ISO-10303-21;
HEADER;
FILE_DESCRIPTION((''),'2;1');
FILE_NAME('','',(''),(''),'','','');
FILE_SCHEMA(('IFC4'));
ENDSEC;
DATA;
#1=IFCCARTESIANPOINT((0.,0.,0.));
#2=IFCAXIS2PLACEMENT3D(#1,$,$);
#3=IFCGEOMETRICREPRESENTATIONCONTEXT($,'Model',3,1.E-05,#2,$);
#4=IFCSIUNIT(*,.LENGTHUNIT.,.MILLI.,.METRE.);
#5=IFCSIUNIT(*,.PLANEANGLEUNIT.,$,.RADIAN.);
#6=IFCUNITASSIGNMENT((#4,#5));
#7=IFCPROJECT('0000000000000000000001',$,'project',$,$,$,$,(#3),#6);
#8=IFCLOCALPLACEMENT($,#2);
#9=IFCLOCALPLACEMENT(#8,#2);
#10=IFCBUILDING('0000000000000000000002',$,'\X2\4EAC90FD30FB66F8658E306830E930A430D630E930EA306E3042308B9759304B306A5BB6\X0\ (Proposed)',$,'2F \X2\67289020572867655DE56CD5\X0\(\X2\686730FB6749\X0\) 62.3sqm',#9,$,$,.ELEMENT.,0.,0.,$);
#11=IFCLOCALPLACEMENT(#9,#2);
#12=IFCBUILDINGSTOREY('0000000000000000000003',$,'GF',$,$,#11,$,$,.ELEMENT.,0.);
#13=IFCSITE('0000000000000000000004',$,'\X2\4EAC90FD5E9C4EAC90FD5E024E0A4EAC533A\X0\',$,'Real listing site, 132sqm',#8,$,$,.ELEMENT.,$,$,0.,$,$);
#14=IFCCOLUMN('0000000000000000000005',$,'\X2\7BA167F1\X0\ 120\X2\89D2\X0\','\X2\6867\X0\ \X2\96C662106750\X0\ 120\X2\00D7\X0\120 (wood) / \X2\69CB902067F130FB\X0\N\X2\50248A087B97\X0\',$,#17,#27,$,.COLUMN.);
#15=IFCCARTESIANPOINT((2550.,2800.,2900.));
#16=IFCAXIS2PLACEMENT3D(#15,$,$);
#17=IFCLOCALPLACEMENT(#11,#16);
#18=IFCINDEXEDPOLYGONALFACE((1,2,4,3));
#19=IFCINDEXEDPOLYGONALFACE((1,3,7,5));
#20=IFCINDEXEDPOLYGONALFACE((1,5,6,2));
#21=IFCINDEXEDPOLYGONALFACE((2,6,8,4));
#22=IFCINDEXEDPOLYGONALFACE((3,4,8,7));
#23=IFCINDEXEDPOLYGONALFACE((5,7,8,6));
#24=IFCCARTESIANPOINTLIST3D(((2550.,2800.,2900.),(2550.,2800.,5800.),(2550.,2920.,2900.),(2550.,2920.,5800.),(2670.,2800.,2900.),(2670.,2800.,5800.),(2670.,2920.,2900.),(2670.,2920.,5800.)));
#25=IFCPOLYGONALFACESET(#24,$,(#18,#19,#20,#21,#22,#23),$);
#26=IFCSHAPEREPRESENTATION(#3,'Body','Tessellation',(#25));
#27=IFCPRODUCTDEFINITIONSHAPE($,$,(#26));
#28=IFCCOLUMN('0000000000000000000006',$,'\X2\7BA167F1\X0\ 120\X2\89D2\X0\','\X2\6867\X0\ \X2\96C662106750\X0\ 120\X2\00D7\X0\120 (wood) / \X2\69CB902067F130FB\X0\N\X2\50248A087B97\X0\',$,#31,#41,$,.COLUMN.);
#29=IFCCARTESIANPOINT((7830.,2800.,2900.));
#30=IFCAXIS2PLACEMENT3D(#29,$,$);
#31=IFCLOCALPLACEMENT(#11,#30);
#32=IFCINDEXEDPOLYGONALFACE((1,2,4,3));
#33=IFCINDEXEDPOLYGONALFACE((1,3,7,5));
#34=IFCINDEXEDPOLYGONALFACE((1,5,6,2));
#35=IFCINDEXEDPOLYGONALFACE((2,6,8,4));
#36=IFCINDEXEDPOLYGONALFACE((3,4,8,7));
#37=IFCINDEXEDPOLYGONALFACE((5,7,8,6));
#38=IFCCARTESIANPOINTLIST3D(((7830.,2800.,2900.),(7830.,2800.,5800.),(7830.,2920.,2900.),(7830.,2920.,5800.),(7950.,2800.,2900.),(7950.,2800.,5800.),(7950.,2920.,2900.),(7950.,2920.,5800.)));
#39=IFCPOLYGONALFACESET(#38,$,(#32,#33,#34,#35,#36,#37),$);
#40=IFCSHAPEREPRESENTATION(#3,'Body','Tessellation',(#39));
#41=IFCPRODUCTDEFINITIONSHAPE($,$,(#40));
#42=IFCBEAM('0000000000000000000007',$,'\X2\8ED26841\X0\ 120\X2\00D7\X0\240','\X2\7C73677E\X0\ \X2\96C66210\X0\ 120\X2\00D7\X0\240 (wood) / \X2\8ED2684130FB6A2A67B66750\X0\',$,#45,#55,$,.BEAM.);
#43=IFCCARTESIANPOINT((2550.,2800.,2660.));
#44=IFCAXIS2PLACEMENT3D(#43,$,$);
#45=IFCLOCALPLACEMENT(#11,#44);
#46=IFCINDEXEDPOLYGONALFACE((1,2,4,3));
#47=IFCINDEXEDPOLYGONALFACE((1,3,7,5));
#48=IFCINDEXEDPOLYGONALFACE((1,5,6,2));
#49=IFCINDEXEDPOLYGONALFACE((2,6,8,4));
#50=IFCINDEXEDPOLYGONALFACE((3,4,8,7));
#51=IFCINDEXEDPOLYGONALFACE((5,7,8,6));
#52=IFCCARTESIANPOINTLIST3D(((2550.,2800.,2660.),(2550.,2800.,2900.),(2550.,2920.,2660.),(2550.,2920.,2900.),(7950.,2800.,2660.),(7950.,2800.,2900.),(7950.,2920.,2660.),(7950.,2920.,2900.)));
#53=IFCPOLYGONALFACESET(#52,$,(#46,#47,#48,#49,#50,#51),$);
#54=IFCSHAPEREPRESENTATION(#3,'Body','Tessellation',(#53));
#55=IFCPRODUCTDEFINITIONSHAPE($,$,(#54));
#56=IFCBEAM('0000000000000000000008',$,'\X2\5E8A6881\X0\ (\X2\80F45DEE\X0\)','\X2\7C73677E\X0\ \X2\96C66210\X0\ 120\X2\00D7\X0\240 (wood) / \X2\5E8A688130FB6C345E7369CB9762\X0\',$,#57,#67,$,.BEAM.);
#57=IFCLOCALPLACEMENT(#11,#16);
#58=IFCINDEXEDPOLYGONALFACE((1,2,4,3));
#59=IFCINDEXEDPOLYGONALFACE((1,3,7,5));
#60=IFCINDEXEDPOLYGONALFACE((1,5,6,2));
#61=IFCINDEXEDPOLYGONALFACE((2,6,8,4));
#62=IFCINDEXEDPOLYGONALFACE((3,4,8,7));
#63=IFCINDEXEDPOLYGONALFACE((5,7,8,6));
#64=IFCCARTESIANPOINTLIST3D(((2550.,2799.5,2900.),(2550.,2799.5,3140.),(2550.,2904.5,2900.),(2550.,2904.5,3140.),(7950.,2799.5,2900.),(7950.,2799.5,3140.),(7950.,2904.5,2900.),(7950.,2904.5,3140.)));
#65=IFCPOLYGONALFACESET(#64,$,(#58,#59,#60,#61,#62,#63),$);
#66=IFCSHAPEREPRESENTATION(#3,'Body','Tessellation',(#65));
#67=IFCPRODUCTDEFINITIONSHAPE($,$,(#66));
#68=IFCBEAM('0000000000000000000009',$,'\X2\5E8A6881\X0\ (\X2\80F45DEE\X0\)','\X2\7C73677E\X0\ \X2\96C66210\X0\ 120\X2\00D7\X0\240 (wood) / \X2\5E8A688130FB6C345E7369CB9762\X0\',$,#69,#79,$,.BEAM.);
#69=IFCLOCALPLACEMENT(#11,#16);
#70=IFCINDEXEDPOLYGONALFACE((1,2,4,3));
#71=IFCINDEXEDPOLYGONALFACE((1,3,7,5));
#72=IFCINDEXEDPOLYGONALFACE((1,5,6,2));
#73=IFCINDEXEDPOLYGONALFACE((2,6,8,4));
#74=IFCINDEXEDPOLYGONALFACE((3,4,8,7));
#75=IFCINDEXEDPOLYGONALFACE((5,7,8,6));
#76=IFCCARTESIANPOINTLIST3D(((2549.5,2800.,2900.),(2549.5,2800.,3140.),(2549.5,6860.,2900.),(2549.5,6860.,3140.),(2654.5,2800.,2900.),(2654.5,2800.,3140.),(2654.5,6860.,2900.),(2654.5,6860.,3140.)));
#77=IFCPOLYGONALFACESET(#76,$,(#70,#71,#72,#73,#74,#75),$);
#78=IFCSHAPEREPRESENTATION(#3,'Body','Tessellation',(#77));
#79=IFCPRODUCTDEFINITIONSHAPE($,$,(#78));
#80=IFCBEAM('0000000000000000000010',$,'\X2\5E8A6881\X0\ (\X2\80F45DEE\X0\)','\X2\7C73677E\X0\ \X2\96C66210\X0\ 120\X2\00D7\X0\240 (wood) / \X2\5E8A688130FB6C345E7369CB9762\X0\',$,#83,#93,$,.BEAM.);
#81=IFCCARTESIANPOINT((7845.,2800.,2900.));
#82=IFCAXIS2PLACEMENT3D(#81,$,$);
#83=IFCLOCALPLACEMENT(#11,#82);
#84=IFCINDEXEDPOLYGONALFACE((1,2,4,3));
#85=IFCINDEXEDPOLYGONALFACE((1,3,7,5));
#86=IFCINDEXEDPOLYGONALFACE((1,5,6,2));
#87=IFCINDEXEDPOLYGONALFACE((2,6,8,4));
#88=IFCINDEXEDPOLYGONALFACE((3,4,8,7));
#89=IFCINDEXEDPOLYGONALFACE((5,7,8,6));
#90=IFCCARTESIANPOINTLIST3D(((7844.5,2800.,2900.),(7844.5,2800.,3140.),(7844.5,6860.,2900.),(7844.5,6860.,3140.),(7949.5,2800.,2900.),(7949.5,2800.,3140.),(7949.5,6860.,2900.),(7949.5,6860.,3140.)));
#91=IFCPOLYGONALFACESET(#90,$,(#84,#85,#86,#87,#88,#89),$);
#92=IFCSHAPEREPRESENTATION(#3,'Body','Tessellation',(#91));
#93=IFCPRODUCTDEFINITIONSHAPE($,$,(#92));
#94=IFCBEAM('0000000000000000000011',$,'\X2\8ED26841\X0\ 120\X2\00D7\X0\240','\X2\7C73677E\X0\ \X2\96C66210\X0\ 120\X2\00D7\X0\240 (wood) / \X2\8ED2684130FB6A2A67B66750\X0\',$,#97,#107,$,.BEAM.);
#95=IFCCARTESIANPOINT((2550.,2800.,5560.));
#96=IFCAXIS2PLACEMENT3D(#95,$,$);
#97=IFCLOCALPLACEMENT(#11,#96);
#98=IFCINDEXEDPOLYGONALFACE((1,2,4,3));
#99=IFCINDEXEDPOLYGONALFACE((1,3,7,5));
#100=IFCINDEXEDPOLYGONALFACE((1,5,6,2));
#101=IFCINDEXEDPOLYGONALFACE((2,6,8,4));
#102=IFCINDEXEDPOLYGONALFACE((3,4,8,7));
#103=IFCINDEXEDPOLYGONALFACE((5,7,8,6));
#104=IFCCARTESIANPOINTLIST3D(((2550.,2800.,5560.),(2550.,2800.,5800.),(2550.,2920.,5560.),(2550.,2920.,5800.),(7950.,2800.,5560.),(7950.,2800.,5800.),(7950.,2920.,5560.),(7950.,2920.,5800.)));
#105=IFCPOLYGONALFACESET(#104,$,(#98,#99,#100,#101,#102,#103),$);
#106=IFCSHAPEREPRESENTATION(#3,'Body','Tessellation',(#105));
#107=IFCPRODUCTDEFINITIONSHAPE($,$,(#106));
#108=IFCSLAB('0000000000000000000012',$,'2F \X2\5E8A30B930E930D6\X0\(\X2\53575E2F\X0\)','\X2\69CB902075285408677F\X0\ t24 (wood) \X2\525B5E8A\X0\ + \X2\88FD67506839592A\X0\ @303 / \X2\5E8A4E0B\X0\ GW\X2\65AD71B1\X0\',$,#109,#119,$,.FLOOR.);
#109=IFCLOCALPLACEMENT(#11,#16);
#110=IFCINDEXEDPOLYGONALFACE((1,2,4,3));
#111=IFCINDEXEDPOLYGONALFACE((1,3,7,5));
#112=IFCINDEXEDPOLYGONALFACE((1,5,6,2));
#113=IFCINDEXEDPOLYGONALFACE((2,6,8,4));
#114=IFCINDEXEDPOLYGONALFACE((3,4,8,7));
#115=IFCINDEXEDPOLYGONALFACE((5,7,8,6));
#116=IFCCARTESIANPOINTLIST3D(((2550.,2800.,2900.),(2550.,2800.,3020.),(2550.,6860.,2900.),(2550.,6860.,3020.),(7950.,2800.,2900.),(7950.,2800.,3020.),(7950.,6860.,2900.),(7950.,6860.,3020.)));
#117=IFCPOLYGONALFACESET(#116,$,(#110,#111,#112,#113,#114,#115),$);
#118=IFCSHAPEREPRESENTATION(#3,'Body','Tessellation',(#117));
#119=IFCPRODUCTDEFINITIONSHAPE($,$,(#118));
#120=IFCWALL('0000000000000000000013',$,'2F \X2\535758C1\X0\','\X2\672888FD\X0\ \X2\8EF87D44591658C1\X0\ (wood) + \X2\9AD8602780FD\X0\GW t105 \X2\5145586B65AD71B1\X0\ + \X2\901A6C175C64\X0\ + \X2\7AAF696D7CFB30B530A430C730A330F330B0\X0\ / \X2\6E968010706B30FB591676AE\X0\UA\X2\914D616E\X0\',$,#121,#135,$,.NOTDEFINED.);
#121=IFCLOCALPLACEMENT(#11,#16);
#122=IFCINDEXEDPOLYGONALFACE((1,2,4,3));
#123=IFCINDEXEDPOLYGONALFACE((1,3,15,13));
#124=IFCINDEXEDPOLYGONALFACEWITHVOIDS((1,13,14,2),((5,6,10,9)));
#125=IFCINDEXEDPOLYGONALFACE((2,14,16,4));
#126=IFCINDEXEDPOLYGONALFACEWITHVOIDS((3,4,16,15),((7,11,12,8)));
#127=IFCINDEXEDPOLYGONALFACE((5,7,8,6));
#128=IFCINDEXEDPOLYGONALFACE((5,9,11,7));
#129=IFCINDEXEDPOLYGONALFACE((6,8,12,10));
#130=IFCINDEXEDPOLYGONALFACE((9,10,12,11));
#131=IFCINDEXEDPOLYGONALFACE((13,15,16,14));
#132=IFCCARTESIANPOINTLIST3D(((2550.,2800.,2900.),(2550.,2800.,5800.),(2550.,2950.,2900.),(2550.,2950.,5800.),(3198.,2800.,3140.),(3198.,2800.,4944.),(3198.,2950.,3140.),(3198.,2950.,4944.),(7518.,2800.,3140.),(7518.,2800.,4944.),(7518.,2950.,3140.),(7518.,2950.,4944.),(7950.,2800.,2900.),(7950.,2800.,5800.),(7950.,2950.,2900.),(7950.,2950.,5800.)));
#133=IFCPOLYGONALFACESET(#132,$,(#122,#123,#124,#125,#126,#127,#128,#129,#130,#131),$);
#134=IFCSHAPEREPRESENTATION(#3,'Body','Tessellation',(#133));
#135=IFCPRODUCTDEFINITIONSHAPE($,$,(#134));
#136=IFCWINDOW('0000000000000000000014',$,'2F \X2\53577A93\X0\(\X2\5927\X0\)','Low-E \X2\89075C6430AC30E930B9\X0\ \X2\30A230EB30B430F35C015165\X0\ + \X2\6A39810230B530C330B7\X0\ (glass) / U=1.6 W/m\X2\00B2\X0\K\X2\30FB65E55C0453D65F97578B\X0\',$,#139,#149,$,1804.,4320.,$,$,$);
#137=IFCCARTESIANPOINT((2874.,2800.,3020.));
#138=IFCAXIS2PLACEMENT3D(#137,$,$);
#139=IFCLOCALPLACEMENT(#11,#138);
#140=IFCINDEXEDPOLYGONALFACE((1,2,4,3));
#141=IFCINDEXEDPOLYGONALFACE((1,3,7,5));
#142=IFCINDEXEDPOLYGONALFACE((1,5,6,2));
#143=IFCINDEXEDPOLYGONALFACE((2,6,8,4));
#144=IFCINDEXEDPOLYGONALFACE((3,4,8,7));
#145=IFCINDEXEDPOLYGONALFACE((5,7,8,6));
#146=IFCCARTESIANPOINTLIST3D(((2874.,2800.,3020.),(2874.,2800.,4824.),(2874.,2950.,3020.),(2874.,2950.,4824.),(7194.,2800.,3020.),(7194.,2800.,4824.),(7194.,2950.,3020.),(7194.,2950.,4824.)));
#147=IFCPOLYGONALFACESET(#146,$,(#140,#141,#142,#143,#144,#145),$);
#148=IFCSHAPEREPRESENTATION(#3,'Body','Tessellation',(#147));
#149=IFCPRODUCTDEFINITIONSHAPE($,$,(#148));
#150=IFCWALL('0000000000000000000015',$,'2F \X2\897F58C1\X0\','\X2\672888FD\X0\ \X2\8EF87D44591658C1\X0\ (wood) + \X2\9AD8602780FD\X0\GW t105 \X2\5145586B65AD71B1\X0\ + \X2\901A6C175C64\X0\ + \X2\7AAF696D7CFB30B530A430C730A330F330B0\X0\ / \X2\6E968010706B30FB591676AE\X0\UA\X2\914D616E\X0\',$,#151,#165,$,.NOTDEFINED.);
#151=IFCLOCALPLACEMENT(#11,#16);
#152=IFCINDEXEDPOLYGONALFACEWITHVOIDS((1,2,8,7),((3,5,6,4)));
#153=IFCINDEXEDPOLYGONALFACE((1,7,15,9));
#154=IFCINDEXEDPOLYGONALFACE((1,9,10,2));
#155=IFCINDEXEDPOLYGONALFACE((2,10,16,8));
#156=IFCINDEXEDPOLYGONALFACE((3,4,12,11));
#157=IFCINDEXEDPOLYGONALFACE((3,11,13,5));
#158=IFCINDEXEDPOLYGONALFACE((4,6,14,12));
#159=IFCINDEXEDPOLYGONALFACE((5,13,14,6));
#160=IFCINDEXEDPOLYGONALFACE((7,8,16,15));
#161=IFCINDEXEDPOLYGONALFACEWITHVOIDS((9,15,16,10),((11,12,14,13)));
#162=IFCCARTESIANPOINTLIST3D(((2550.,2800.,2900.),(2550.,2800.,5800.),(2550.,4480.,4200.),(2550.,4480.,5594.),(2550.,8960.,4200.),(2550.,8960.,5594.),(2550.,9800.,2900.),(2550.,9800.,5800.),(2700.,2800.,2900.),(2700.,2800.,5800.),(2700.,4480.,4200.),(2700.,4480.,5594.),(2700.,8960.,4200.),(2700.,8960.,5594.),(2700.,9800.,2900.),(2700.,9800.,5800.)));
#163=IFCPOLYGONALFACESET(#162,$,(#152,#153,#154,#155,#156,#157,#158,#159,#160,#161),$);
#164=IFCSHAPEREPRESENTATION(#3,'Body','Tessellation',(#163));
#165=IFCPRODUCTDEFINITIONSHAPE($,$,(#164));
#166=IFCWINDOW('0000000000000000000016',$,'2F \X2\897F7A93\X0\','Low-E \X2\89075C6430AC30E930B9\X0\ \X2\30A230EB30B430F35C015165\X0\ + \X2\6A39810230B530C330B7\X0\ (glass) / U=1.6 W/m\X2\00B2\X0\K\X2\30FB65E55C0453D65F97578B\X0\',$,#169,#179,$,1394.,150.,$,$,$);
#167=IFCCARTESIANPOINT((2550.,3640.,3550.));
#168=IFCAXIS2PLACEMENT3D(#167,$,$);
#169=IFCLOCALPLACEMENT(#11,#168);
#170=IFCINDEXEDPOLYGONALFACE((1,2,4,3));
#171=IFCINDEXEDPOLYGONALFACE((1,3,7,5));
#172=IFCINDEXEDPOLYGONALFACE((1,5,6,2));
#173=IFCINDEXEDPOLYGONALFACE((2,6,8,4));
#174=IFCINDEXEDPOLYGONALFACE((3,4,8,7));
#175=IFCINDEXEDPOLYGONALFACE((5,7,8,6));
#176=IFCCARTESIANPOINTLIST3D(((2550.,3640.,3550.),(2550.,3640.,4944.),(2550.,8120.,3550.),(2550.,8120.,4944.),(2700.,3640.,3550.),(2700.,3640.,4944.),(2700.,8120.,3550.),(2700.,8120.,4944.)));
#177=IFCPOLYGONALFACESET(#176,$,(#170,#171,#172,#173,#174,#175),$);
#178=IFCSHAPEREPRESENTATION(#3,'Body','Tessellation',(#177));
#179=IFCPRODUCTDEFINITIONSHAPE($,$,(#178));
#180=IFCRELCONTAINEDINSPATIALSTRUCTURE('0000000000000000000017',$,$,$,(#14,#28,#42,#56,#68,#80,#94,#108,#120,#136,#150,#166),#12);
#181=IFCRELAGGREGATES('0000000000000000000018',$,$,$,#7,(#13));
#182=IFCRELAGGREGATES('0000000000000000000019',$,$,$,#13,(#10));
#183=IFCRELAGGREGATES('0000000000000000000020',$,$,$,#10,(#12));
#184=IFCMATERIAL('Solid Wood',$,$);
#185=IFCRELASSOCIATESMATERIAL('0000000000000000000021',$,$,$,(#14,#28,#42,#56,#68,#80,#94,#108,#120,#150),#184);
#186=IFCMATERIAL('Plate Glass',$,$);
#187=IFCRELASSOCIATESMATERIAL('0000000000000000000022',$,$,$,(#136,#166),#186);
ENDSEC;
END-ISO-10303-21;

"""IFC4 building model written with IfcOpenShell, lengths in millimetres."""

from ifc_helpers import new_model, si_unit, frame, frame_2d, origin, place, context, project, spatial, rectangle, extrude, material, element, fill, save


model = new_model("IFC4")

# Units and contexts
model_context = context("Model", 3, precision=1e-05, world=origin())
ifc_project = project(units=[si_unit("LENGTHUNIT", "METRE", prefix="MILLI"), si_unit("PLANEANGLEUNIT", "RADIAN")], contexts=[model_context])

# Site, building, storey
site_placement = place(None, origin())
site = spatial("IfcSite", under=ifc_project, at=site_placement, Name="京都府京都市上京区", ObjectType="Real listing site, 132sqm", CompositionType="ELEMENT", RefElevation=0.0)
building_placement = place(site_placement, origin())
building = spatial("IfcBuilding", under=site, at=building_placement, Name="京都・書斎とライブラリのある静かな家 (Proposed)", ObjectType="2F 木造在来工法(桧・杉) 62.3sqm", CompositionType="ELEMENT", ElevationOfRefHeight=0.0, ElevationOfTerrain=0.0)
storey_placement = place(building_placement, origin())
storey = spatial("IfcBuildingStorey", under=building, at=storey_placement, Name="GF", CompositionType="ELEMENT", Elevation=0.0)

# Columns
ifc_material_1 = material(Name="Solid Wood")
column_1_placement = place(storey_placement, frame((2550.0, 2800.0, 2900.0)))
element("IfcColumn", 1, at=column_1_placement, inside=storey, material=ifc_material_1, Name="管柱 120角", Description="桧 集成材 120×120 (wood) / 構造柱・N値計算", PredefinedType="COLUMN", context=model_context, shape_type="SweptSolid", body=[
    extrude(rectangle(XDim=120.0, YDim=120.0, at=frame_2d((60.0, 60.0))), frame((2550.0, 2800.0, 2900.0)), (0.0, 0.0, 1.0), 2900.0),
])
column_2_placement = place(storey_placement, frame((7830.0, 2800.0, 2900.0)))
element("IfcColumn", 2, at=column_2_placement, inside=storey, material=ifc_material_1, Name="管柱 120角", Description="桧 集成材 120×120 (wood) / 構造柱・N値計算", PredefinedType="COLUMN", context=model_context, shape_type="SweptSolid", body=[
    extrude(rectangle(XDim=120.0, YDim=120.0, at=frame_2d((60.0, 60.0))), frame((7830.0, 2800.0, 2900.0)), (0.0, 0.0, 1.0), 2900.0),
])

# Beams
beam_1_placement = place(storey_placement, frame((2550.0, 2800.0, 2660.0)))
element("IfcBeam", 3, at=beam_1_placement, inside=storey, material=ifc_material_1, Name="軒桁 120×240", Description="米松 集成 120×240 (wood) / 軒桁・横架材", PredefinedType="BEAM", context=model_context, shape_type="SweptSolid", body=[
    extrude(rectangle(XDim=5400.0, YDim=120.0, at=frame_2d((2700.0, 60.0))), frame((2550.0, 2800.0, 2660.0)), (0.0, 0.0, 1.0), 240.0),
])
beam_2_placement = place(storey_placement, frame((2550.0, 2800.0, 2900.0)))
element("IfcBeam", 4, at=beam_2_placement, inside=storey, material=ifc_material_1, Name="床梁 (胴差)", Description="米松 集成 120×240 (wood) / 床梁・水平構面", PredefinedType="BEAM", context=model_context, shape_type="SweptSolid", body=[
    extrude(rectangle(XDim=5400.0, YDim=105.0, at=frame_2d((2700.0, 52.0))), frame((2550.0, 2800.0, 2900.0)), (0.0, 0.0, 1.0), 240.0),
])
beam_3_placement = place(storey_placement, frame((2550.0, 2800.0, 2900.0)))
element("IfcBeam", 5, at=beam_3_placement, inside=storey, material=ifc_material_1, Name="床梁 (胴差)", Description="米松 集成 120×240 (wood) / 床梁・水平構面", PredefinedType="BEAM", context=model_context, shape_type="SweptSolid", body=[
    extrude(rectangle(XDim=105.0, YDim=4060.0, at=frame_2d((52.0, 2030.0))), frame((2550.0, 2800.0, 2900.0)), (0.0, 0.0, 1.0), 240.0),
])
beam_4_placement = place(storey_placement, frame((7845.0, 2800.0, 2900.0)))
element("IfcBeam", 6, at=beam_4_placement, inside=storey, material=ifc_material_1, Name="床梁 (胴差)", Description="米松 集成 120×240 (wood) / 床梁・水平構面", PredefinedType="BEAM", context=model_context, shape_type="SweptSolid", body=[
    extrude(rectangle(XDim=105.0, YDim=4060.0, at=frame_2d((52.0, 2030.0))), frame((7845.0, 2800.0, 2900.0)), (0.0, 0.0, 1.0), 240.0),
])
beam_5_placement = place(storey_placement, frame((2550.0, 2800.0, 5560.0)))
element("IfcBeam", 7, at=beam_5_placement, inside=storey, material=ifc_material_1, Name="軒桁 120×240", Description="米松 集成 120×240 (wood) / 軒桁・横架材", PredefinedType="BEAM", context=model_context, shape_type="SweptSolid", body=[
    extrude(rectangle(XDim=5400.0, YDim=120.0, at=frame_2d((2700.0, 60.0))), frame((2550.0, 2800.0, 5560.0)), (0.0, 0.0, 1.0), 240.0),
])

# Slab
slab_placement = place(storey_placement, frame((2550.0, 2800.0, 2900.0)))
element("IfcSlab", 8, at=slab_placement, inside=storey, material=ifc_material_1, Name="2F 床スラブ(南帯)", Description="構造用合板 t24 (wood) 剛床 + 製材根太 @303 / 床下 GW断熱", PredefinedType="FLOOR", context=model_context, shape_type="SweptSolid", body=[
    extrude(rectangle(XDim=5400.0, YDim=4060.0, at=frame_2d((2700.0, 2030.0))), frame((2550.0, 2800.0, 2900.0)), (0.0, 0.0, 1.0), 120.0),
])

# Walls, openings, windows
wall_1_placement = place(storey_placement, frame((2550.0, 2800.0, 2900.0)))
wall_1 = element("IfcWall", 9, at=wall_1_placement, inside=storey, material=ifc_material_1, Name="2F 南壁", Description="木製 軸組外壁 (wood) + 高性能GW t105 充填断熱 + 通気層 + 窯業系サイディング / 準耐火・外皮UA配慮", PredefinedType="NOTDEFINED", context=model_context, shape_type="SweptSolid", body=[
    extrude(rectangle(XDim=5400.0, YDim=150.0, at=frame_2d((2700.0, 75.0))), frame((2550.0, 2800.0, 2900.0)), (0.0, 0.0, 1.0), 2900.0),
])
opening_1_placement = place(storey_placement, frame((2874.0, 2800.0, 3020.0)))
opening_1 = element("IfcOpeningElement", 10, at=opening_1_placement, cuts=wall_1, PredefinedType="NOTDEFINED", context=model_context, shape_type="SweptSolid", body=[
    extrude(rectangle(XDim=4320.0, YDim=150.0, at=frame_2d((2160.0, 75.0))), frame((2874.0, 2800.0, 3020.0)), (0.0, 0.0, 1.0), 1804.0),
])
ifc_material_2 = material(Name="Plate Glass")
window_1_placement = place(storey_placement, frame((2874.0, 2800.0, 3020.0)))
window_1 = element("IfcWindow", 11, at=window_1_placement, inside=storey, material=ifc_material_2, Name="2F 南窓(大)", Description="Low-E 複層ガラス アルゴン封入 + 樹脂サッシ (glass) / U=1.6 W/m²K・日射取得型", OverallHeight=1804.0, OverallWidth=4320.0, context=model_context, shape_type="SweptSolid", body=[
    extrude(rectangle(XDim=4320.0, YDim=150.0, at=frame_2d((2160.0, 75.0))), frame((2874.0, 2800.0, 3020.0)), (0.0, 0.0, 1.0), 1804.0),
])
fill(opening_1, window_1)
wall_2_placement = place(storey_placement, frame((2550.0, 2800.0, 2900.0)))
wall_2 = element("IfcWall", 12, at=wall_2_placement, inside=storey, material=ifc_material_1, Name="2F 西壁", Description="木製 軸組外壁 (wood) + 高性能GW t105 充填断熱 + 通気層 + 窯業系サイディング / 準耐火・外皮UA配慮", PredefinedType="NOTDEFINED", context=model_context, shape_type="SweptSolid", body=[
    extrude(rectangle(XDim=150.0, YDim=7000.0, at=frame_2d((75.0, 3500.0))), frame((2550.0, 2800.0, 2900.0)), (0.0, 0.0, 1.0), 2900.0),
])
opening_2_placement = place(storey_placement, frame((2550.0, 3640.0, 3550.0)))
opening_2 = element("IfcOpeningElement", 13, at=opening_2_placement, cuts=wall_2, PredefinedType="NOTDEFINED", context=model_context, shape_type="SweptSolid", body=[
    extrude(rectangle(XDim=150.0, YDim=4480.0, at=frame_2d((75.0, 2240.0))), frame((2550.0, 3640.0, 3550.0)), (0.0, 0.0, 1.0), 1394.0),
])
window_2_placement = place(storey_placement, frame((2550.0, 3640.0, 3550.0)))
window_2 = element("IfcWindow", 14, at=window_2_placement, inside=storey, material=ifc_material_2, Name="2F 西窓", Description="Low-E 複層ガラス アルゴン封入 + 樹脂サッシ (glass) / U=1.6 W/m²K・日射取得型", OverallHeight=1394.0, OverallWidth=150.0, context=model_context, shape_type="SweptSolid", body=[
    extrude(rectangle(XDim=150.0, YDim=4480.0, at=frame_2d((75.0, 2240.0))), frame((2550.0, 3640.0, 3550.0)), (0.0, 0.0, 1.0), 1394.0),
])
fill(opening_2, window_2)

save(model, "model.ifc")
